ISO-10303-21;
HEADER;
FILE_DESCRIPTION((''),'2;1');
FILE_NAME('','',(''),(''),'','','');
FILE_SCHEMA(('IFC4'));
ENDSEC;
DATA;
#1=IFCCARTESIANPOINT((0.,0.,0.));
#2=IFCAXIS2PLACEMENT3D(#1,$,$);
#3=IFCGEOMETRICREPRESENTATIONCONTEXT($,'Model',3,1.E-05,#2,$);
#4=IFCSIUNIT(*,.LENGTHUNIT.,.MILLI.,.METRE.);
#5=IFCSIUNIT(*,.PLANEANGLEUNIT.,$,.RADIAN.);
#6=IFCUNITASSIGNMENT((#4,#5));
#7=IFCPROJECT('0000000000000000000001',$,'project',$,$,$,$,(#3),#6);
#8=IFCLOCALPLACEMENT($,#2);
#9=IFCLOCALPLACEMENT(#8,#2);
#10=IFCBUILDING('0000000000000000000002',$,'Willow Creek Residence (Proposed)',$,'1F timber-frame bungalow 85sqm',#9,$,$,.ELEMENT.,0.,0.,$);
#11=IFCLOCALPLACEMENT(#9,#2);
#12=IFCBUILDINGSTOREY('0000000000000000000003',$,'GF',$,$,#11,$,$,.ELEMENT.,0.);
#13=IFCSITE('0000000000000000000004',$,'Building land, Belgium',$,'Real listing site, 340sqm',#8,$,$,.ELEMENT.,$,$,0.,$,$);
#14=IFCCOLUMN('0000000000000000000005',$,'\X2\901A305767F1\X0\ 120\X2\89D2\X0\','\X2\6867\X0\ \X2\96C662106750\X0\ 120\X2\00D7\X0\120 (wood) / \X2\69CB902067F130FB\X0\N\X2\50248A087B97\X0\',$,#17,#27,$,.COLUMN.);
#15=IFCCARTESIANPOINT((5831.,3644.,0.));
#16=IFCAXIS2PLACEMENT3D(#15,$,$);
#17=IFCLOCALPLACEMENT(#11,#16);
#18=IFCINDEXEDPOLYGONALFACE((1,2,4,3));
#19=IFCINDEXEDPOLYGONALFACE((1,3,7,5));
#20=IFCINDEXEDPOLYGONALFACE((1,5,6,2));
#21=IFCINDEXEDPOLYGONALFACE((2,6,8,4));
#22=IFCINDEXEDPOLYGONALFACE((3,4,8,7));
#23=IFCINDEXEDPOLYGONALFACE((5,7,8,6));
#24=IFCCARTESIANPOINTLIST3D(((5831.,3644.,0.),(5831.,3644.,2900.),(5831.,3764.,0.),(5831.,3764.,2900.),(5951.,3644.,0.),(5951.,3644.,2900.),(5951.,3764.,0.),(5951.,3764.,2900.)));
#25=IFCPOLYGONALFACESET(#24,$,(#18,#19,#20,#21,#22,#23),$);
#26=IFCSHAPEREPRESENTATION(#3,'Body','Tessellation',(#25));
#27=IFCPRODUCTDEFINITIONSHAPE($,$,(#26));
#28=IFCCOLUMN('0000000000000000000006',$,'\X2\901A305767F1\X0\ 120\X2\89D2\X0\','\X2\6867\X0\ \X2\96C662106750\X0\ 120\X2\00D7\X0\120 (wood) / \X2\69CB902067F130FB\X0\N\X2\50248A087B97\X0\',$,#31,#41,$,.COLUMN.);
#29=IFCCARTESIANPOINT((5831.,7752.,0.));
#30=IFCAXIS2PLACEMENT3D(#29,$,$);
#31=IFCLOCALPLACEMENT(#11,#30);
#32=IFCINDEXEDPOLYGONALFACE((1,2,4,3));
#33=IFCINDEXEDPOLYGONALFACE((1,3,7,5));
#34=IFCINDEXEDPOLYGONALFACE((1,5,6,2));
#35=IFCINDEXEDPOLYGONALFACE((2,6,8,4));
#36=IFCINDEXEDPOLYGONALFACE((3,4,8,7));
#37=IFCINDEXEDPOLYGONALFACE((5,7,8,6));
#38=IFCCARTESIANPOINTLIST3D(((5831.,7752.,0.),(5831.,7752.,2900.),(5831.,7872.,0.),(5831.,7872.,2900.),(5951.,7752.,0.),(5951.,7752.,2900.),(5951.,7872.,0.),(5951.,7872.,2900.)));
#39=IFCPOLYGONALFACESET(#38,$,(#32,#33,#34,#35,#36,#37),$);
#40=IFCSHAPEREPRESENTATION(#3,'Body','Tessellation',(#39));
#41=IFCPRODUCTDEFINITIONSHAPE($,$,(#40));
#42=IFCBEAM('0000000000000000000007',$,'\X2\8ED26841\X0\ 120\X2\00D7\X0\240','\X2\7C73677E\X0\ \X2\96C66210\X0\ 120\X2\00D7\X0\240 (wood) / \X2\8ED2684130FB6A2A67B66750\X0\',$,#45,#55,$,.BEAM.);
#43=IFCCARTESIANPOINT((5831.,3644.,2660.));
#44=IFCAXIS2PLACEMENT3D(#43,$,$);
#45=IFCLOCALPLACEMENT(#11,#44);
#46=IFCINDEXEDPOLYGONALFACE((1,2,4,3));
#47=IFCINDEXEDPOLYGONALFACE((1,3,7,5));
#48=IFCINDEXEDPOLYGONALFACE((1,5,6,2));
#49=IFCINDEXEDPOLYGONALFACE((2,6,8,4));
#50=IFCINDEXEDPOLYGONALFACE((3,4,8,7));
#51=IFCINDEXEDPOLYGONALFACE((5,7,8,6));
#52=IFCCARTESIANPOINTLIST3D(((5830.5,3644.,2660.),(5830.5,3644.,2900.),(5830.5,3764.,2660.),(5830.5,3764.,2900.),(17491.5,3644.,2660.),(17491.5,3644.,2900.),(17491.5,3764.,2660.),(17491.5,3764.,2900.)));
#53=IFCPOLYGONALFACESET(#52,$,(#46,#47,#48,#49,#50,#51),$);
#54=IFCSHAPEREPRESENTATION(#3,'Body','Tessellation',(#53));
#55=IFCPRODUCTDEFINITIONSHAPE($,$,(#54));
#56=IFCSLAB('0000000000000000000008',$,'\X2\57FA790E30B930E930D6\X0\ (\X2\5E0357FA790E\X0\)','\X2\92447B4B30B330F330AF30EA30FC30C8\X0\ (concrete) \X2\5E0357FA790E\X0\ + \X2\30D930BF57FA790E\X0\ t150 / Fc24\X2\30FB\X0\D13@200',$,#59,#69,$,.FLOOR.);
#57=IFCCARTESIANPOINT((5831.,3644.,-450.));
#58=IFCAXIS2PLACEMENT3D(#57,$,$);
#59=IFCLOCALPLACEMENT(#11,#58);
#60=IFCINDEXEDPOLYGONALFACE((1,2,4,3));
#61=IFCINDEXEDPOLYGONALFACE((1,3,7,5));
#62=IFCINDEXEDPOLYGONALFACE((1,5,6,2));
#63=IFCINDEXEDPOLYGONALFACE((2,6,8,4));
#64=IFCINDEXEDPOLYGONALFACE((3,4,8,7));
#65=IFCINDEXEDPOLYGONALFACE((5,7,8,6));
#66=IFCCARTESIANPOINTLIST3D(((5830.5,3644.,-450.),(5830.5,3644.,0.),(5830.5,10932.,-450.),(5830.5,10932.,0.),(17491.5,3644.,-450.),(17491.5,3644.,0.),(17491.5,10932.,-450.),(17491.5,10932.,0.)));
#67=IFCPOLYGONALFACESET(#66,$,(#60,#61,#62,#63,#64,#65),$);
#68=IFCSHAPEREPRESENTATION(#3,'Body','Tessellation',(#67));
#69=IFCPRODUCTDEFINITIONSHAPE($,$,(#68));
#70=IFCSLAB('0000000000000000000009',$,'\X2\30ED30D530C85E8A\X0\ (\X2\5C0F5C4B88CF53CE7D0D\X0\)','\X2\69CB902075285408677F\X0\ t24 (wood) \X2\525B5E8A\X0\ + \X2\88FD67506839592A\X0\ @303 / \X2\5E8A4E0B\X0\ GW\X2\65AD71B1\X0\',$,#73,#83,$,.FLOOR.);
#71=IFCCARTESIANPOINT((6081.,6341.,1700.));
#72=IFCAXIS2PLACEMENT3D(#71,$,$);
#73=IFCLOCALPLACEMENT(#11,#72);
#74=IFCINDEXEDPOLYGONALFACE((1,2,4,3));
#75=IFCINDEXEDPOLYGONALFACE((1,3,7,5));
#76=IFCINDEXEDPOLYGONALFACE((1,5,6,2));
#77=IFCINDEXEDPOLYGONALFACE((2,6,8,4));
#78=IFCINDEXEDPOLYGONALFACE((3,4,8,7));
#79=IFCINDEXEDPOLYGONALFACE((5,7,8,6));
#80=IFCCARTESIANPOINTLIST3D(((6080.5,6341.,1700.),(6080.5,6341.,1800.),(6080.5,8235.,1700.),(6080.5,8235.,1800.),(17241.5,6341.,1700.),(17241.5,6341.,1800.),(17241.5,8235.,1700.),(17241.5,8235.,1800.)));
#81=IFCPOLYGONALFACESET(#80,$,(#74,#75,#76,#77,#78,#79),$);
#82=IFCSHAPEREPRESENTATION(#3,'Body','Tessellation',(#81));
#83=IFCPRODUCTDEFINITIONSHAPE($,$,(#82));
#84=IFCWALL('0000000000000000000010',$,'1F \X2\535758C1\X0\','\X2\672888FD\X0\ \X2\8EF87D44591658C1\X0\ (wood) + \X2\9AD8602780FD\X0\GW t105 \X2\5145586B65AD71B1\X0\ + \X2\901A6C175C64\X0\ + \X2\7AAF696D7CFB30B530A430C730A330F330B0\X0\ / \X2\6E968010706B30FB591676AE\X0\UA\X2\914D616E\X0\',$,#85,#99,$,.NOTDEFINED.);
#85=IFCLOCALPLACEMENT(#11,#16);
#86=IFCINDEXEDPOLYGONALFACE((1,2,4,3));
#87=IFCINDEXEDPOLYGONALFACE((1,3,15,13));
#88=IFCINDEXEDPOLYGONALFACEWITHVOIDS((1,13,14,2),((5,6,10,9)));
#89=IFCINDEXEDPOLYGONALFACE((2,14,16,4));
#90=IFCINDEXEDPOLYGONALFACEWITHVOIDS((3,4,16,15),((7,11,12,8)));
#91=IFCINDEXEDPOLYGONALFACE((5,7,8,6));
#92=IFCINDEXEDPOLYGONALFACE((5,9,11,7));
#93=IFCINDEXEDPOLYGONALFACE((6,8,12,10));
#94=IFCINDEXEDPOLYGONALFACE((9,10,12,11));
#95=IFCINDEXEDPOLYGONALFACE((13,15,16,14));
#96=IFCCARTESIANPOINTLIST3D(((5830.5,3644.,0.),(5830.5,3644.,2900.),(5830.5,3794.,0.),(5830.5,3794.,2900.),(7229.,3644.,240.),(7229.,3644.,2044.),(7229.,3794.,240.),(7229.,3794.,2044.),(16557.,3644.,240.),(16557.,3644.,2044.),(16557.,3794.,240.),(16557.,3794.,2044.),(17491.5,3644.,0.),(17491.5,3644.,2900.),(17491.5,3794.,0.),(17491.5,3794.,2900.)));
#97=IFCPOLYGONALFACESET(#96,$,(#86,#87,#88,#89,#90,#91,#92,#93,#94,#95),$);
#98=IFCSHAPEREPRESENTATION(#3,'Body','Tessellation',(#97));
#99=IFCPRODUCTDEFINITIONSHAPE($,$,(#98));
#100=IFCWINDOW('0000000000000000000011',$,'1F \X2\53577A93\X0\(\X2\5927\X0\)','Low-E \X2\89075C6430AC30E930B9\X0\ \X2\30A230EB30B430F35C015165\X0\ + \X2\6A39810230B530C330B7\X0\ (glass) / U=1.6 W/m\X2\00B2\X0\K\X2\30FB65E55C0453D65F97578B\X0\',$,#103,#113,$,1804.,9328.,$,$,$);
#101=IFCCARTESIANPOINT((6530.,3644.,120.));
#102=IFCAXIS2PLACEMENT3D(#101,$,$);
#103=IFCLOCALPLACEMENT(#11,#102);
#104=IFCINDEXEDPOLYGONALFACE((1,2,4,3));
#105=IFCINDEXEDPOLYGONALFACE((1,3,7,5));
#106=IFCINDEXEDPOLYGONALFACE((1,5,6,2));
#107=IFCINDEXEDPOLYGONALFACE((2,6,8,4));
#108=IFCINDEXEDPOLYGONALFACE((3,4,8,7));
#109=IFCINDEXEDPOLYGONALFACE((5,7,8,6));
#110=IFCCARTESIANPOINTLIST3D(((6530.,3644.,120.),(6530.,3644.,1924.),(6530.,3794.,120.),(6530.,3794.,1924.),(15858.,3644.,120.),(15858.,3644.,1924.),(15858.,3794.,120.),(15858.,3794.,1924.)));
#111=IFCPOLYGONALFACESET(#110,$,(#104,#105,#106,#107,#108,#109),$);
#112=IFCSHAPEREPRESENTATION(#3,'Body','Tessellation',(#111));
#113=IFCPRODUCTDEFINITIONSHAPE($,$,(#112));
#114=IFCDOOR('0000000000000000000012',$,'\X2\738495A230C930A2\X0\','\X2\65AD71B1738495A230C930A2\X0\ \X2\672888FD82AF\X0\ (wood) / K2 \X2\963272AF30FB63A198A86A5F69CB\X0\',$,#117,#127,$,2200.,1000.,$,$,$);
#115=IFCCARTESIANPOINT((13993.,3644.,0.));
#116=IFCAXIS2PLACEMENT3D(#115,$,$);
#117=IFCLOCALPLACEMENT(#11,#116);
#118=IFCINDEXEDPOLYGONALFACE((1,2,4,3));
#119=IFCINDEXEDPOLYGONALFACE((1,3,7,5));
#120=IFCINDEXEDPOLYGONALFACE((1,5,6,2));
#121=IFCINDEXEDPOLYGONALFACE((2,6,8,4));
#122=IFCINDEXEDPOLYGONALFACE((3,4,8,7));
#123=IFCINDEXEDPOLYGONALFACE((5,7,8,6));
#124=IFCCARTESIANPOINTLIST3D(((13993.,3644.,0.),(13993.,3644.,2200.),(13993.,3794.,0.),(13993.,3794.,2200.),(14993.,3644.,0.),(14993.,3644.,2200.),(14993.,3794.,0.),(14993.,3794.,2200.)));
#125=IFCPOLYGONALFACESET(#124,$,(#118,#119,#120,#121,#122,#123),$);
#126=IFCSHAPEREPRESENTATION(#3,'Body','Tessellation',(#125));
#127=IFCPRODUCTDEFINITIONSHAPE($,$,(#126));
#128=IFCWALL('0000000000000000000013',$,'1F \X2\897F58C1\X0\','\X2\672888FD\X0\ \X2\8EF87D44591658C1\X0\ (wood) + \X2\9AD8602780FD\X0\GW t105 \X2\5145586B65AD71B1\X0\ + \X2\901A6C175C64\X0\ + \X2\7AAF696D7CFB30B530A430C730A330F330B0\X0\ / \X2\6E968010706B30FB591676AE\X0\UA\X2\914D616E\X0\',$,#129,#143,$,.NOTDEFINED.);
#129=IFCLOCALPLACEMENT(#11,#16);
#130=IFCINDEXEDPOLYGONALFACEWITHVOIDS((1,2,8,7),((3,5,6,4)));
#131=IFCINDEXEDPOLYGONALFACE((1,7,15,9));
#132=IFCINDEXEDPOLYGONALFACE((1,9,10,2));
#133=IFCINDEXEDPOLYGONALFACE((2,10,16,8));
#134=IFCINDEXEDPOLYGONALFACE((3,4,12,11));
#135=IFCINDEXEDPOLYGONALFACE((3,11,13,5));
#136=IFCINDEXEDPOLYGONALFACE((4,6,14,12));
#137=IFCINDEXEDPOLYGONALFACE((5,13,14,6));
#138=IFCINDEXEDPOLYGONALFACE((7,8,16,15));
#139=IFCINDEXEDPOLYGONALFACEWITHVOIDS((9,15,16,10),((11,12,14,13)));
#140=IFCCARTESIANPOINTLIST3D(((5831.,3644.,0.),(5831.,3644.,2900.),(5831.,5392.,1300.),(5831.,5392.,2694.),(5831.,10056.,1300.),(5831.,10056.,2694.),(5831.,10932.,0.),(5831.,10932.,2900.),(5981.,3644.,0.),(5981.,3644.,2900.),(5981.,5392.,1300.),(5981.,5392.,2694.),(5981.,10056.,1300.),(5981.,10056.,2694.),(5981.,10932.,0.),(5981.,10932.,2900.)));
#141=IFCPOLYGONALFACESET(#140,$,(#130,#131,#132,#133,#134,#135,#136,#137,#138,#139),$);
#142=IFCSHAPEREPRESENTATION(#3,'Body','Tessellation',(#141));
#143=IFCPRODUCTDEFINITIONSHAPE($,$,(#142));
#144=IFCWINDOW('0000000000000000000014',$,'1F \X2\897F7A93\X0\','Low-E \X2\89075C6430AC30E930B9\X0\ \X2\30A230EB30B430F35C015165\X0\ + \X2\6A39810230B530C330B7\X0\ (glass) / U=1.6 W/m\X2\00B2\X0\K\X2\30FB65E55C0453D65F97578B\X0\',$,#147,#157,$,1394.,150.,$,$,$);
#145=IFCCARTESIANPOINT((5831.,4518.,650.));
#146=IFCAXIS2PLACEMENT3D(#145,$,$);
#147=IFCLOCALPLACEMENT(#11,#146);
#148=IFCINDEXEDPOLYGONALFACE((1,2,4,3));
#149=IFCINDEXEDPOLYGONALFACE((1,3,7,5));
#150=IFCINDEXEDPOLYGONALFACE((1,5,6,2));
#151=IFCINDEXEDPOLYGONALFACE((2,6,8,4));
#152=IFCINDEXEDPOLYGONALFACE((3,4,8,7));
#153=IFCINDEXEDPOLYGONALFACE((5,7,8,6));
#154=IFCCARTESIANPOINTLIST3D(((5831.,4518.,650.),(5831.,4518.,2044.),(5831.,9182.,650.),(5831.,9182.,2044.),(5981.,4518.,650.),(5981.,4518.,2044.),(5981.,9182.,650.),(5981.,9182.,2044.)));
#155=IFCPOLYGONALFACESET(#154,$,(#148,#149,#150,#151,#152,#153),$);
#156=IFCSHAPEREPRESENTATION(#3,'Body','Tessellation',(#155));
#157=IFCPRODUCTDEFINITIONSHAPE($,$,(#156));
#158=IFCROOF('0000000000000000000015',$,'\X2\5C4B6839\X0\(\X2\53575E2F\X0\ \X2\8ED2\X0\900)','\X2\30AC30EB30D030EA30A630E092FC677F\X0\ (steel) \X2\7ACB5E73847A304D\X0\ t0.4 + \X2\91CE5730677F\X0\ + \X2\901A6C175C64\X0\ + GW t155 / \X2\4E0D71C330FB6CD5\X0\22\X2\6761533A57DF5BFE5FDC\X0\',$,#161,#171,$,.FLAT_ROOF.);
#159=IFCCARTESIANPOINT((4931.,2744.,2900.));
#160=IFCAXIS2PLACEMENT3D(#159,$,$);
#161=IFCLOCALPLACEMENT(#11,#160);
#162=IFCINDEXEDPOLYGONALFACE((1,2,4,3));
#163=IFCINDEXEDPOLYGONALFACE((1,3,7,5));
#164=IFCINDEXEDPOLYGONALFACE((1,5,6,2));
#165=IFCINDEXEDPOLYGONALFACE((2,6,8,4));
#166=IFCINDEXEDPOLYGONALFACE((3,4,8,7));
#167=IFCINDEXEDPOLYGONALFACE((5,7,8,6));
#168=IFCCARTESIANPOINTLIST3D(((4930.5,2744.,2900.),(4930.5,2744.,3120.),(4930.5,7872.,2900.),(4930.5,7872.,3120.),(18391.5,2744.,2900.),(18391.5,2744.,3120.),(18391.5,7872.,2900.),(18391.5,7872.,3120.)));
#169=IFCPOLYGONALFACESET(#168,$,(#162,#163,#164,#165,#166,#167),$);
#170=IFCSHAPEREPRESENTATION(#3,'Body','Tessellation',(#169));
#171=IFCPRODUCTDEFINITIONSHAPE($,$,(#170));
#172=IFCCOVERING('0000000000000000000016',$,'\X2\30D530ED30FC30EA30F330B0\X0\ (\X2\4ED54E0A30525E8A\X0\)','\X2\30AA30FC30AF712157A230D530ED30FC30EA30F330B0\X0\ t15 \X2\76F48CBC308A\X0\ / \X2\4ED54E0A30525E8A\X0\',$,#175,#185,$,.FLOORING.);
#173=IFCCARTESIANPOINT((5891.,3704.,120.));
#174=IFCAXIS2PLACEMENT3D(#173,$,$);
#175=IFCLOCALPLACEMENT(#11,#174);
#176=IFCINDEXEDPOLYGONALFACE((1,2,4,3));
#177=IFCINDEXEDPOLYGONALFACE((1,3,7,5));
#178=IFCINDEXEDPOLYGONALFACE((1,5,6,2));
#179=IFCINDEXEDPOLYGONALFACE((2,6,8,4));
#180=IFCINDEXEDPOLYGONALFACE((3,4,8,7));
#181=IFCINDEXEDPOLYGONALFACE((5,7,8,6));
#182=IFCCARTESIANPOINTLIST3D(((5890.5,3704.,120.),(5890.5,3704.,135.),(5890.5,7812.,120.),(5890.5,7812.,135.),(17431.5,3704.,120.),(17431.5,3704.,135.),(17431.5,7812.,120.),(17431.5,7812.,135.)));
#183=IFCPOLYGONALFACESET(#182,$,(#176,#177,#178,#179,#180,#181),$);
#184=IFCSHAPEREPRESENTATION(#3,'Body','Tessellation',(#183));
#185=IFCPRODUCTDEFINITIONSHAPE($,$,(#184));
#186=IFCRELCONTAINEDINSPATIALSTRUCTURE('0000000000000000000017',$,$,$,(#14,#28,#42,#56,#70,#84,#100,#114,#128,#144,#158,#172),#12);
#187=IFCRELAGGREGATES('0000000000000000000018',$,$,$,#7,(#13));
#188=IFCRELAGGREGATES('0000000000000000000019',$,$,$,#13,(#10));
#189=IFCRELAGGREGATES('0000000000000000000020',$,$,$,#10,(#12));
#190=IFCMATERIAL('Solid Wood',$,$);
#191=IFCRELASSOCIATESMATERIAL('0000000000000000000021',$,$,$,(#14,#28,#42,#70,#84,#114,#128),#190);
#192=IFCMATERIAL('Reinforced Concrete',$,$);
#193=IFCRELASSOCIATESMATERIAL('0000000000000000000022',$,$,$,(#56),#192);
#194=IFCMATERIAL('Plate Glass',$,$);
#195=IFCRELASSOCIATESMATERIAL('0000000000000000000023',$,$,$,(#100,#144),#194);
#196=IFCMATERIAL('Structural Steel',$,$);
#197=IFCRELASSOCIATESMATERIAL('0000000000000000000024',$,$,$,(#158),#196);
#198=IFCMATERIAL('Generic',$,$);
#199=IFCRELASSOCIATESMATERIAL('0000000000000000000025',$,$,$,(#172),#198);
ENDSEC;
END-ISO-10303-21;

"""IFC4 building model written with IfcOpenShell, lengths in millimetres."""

from ifc_helpers import new_model, si_unit, frame, frame_2d, origin, place, context, project, spatial, rectangle, extrude, material, element, fill, save


model = new_model("IFC4")

# Units and contexts
model_context = context("Model", 3, precision=1e-05, world=origin())
ifc_project = project(units=[si_unit("LENGTHUNIT", "METRE", prefix="MILLI"), si_unit("PLANEANGLEUNIT", "RADIAN")], contexts=[model_context])

# Site, building, storey
site_placement = place(None, origin())
site = spatial("IfcSite", under=ifc_project, at=site_placement, Name="Building land, Belgium", ObjectType="Real listing site, 340sqm", CompositionType="ELEMENT", RefElevation=0.0)
building_placement = place(site_placement, origin())
building = spatial("IfcBuilding", under=site, at=building_placement, Name="Willow Creek Residence (Proposed)", ObjectType="1F timber-frame bungalow 85sqm", CompositionType="ELEMENT", ElevationOfRefHeight=0.0, ElevationOfTerrain=0.0)
storey_placement = place(building_placement, origin())
storey = spatial("IfcBuildingStorey", under=building, at=storey_placement, Name="GF", CompositionType="ELEMENT", Elevation=0.0)

# Columns
ifc_material_1 = material(Name="Solid Wood")
column_1_placement = place(storey_placement, frame((5831.0, 3644.0, 0.0)))
element("IfcColumn", 1, at=column_1_placement, inside=storey, material=ifc_material_1, Name="通し柱 120角", Description="桧 集成材 120×120 (wood) / 構造柱・N値計算", PredefinedType="COLUMN", context=model_context, shape_type="SweptSolid", body=[
    extrude(rectangle(XDim=120.0, YDim=120.0, at=frame_2d((60.0, 60.0))), frame((5831.0, 3644.0, 0.0)), (0.0, 0.0, 1.0), 2900.0),
])
column_2_placement = place(storey_placement, frame((5831.0, 7752.0, 0.0)))
element("IfcColumn", 2, at=column_2_placement, inside=storey, material=ifc_material_1, Name="通し柱 120角", Description="桧 集成材 120×120 (wood) / 構造柱・N値計算", PredefinedType="COLUMN", context=model_context, shape_type="SweptSolid", body=[
    extrude(rectangle(XDim=120.0, YDim=120.0, at=frame_2d((60.0, 60.0))), frame((5831.0, 7752.0, 0.0)), (0.0, 0.0, 1.0), 2900.0),
])

# Beam
beam_1_placement = place(storey_placement, frame((5831.0, 3644.0, 2660.0)))
element("IfcBeam", 3, at=beam_1_placement, inside=storey, material=ifc_material_1, Name="軒桁 120×240", Description="米松 集成 120×240 (wood) / 軒桁・横架材", PredefinedType="BEAM", context=model_context, shape_type="SweptSolid", body=[
    extrude(rectangle(XDim=11661.0, YDim=120.0, at=frame_2d((5830.0, 60.0))), frame((5831.0, 3644.0, 2660.0)), (0.0, 0.0, 1.0), 240.0),
])

# Slabs
ifc_material_2 = material(Name="Reinforced Concrete")
slab_1_placement = place(storey_placement, frame((5831.0, 3644.0, -450.0)))
element("IfcSlab", 4, at=slab_1_placement, inside=storey, material=ifc_material_2, Name="基礎スラブ (布基礎)", Description="鉄筋コンクリート (concrete) 布基礎 + ベタ基礎 t150 / Fc24・D13@200", PredefinedType="FLOOR", context=model_context, shape_type="SweptSolid", body=[
    extrude(rectangle(XDim=11661.0, YDim=7288.0, at=frame_2d((5830.0, 3644.0))), frame((5831.0, 3644.0, -450.0)), (0.0, 0.0, 1.0), 450.0),
])
slab_2_placement = place(storey_placement, frame((6081.0, 6341.0, 1700.0)))
element("IfcSlab", 5, at=slab_2_placement, inside=storey, material=ifc_material_1, Name="ロフト床 (小屋裏収納)", Description="構造用合板 t24 (wood) 剛床 + 製材根太 @303 / 床下 GW断熱", PredefinedType="FLOOR", context=model_context, shape_type="SweptSolid", body=[
    extrude(rectangle(XDim=11161.0, YDim=1894.0, at=frame_2d((5580.0, 947.0))), frame((6081.0, 6341.0, 1700.0)), (0.0, 0.0, 1.0), 100.0),
])

# Wall, openings, window, door
wall_1_placement = place(storey_placement, frame((5831.0, 3644.0, 0.0)))
wall_1 = element("IfcWall", 6, at=wall_1_placement, inside=storey, material=ifc_material_1, Name="1F 南壁", Description="木製 軸組外壁 (wood) + 高性能GW t105 充填断熱 + 通気層 + 窯業系サイディング / 準耐火・外皮UA配慮", PredefinedType="NOTDEFINED", context=model_context, shape_type="SweptSolid", body=[
    extrude(rectangle(XDim=11661.0, YDim=150.0, at=frame_2d((5830.0, 75.0))), frame((5831.0, 3644.0, 0.0)), (0.0, 0.0, 1.0), 2900.0),
])
opening_1_placement = place(storey_placement, frame((6530.0, 3644.0, 120.0)))
opening_1 = element("IfcOpeningElement", 7, at=opening_1_placement, cuts=wall_1, PredefinedType="NOTDEFINED", context=model_context, shape_type="SweptSolid", body=[
    extrude(rectangle(XDim=9328.0, YDim=150.0, at=frame_2d((4664.0, 75.0))), frame((6530.0, 3644.0, 120.0)), (0.0, 0.0, 1.0), 1804.0),
])
opening_2_placement = place(storey_placement, frame((13993.0, 3644.0, 0.0)))
opening_2 = element("IfcOpeningElement", 8, at=opening_2_placement, cuts=wall_1, PredefinedType="NOTDEFINED", context=model_context, shape_type="SweptSolid", body=[
    extrude(rectangle(XDim=1000.0, YDim=150.0, at=frame_2d((500.0, 75.0))), frame((13993.0, 3644.0, 0.0)), (0.0, 0.0, 1.0), 2200.0),
])
ifc_material_3 = material(Name="Plate Glass")
window_1_placement = place(storey_placement, frame((6530.0, 3644.0, 120.0)))
window_1 = element("IfcWindow", 9, at=window_1_placement, inside=storey, material=ifc_material_3, Name="1F 南窓(大)", Description="Low-E 複層ガラス アルゴン封入 + 樹脂サッシ (glass) / U=1.6 W/m²K・日射取得型", OverallHeight=1804.0, OverallWidth=9328.0, context=model_context, shape_type="SweptSolid", body=[
    extrude(rectangle(XDim=9328.0, YDim=150.0, at=frame_2d((4664.0, 75.0))), frame((6530.0, 3644.0, 120.0)), (0.0, 0.0, 1.0), 1804.0),
])
fill(opening_1, window_1)
door_placement = place(storey_placement, frame((13993.0, 3644.0, 0.0)))
door = element("IfcDoor", 10, at=door_placement, inside=storey, material=ifc_material_1, Name="玄関ドア", Description="断熱玄関ドア 木製芯 (wood) / K2 防犯・採風機構", OverallHeight=2200.0, OverallWidth=1000.0, context=model_context, shape_type="SweptSolid", body=[
    extrude(rectangle(XDim=1000.0, YDim=150.0, at=frame_2d((500.0, 75.0))), frame((13993.0, 3644.0, 0.0)), (0.0, 0.0, 1.0), 2200.0),
])
fill(opening_2, door)

# Wall, opening, window
wall_2_placement = place(storey_placement, frame((5831.0, 3644.0, 0.0)))
wall_2 = element("IfcWall", 11, at=wall_2_placement, inside=storey, material=ifc_material_1, Name="1F 西壁", Description="木製 軸組外壁 (wood) + 高性能GW t105 充填断熱 + 通気層 + 窯業系サイディング / 準耐火・外皮UA配慮", PredefinedType="NOTDEFINED", context=model_context, shape_type="SweptSolid", body=[
    extrude(rectangle(XDim=150.0, YDim=7288.0, at=frame_2d((75.0, 3644.0))), frame((5831.0, 3644.0, 0.0)), (0.0, 0.0, 1.0), 2900.0),
])
opening_3_placement = place(storey_placement, frame((5831.0, 4518.0, 650.0)))
opening_3 = element("IfcOpeningElement", 12, at=opening_3_placement, cuts=wall_2, PredefinedType="NOTDEFINED", context=model_context, shape_type="SweptSolid", body=[
    extrude(rectangle(XDim=150.0, YDim=4664.0, at=frame_2d((75.0, 2332.0))), frame((5831.0, 4518.0, 650.0)), (0.0, 0.0, 1.0), 1394.0),
])
window_2_placement = place(storey_placement, frame((5831.0, 4518.0, 650.0)))
window_2 = element("IfcWindow", 13, at=window_2_placement, inside=storey, material=ifc_material_3, Name="1F 西窓", Description="Low-E 複層ガラス アルゴン封入 + 樹脂サッシ (glass) / U=1.6 W/m²K・日射取得型", OverallHeight=1394.0, OverallWidth=150.0, context=model_context, shape_type="SweptSolid", body=[
    extrude(rectangle(XDim=150.0, YDim=4664.0, at=frame_2d((75.0, 2332.0))), frame((5831.0, 4518.0, 650.0)), (0.0, 0.0, 1.0), 1394.0),
])
fill(opening_3, window_2)

# Roof
ifc_material_4 = material(Name="Structural Steel")
roof_placement = place(storey_placement, frame((4931.0, 2744.0, 2900.0)))
element("IfcRoof", 14, at=roof_placement, inside=storey, material=ifc_material_4, Name="屋根(南帯 軒900)", Description="ガルバリウム鋼板 (steel) 立平葺き t0.4 + 野地板 + 通気層 + GW t155 / 不燃・法22条区域対応", PredefinedType="FLAT_ROOF", context=model_context, shape_type="SweptSolid", body=[
    extrude(rectangle(XDim=13461.0, YDim=5128.0, at=frame_2d((6730.0, 2564.0))), frame((4931.0, 2744.0, 2900.0)), (0.0, 0.0, 1.0), 220.0),
])

# Covering
ifc_material_5 = material(Name="Generic")
covering_1_placement = place(storey_placement, frame((5891.0, 3704.0, 120.0)))
element("IfcCovering", 15, at=covering_1_placement, inside=storey, material=ifc_material_5, Name="フローリング (仕上げ床)", Description="オーク無垢フローリング t15 直貼り / 仕上げ床", PredefinedType="FLOORING", context=model_context, shape_type="SweptSolid", body=[
    extrude(rectangle(XDim=11541.0, YDim=4108.0, at=frame_2d((5770.0, 2054.0))), frame((5891.0, 3704.0, 120.0)), (0.0, 0.0, 1.0), 15.0),
])

save(model, "model.ifc")
